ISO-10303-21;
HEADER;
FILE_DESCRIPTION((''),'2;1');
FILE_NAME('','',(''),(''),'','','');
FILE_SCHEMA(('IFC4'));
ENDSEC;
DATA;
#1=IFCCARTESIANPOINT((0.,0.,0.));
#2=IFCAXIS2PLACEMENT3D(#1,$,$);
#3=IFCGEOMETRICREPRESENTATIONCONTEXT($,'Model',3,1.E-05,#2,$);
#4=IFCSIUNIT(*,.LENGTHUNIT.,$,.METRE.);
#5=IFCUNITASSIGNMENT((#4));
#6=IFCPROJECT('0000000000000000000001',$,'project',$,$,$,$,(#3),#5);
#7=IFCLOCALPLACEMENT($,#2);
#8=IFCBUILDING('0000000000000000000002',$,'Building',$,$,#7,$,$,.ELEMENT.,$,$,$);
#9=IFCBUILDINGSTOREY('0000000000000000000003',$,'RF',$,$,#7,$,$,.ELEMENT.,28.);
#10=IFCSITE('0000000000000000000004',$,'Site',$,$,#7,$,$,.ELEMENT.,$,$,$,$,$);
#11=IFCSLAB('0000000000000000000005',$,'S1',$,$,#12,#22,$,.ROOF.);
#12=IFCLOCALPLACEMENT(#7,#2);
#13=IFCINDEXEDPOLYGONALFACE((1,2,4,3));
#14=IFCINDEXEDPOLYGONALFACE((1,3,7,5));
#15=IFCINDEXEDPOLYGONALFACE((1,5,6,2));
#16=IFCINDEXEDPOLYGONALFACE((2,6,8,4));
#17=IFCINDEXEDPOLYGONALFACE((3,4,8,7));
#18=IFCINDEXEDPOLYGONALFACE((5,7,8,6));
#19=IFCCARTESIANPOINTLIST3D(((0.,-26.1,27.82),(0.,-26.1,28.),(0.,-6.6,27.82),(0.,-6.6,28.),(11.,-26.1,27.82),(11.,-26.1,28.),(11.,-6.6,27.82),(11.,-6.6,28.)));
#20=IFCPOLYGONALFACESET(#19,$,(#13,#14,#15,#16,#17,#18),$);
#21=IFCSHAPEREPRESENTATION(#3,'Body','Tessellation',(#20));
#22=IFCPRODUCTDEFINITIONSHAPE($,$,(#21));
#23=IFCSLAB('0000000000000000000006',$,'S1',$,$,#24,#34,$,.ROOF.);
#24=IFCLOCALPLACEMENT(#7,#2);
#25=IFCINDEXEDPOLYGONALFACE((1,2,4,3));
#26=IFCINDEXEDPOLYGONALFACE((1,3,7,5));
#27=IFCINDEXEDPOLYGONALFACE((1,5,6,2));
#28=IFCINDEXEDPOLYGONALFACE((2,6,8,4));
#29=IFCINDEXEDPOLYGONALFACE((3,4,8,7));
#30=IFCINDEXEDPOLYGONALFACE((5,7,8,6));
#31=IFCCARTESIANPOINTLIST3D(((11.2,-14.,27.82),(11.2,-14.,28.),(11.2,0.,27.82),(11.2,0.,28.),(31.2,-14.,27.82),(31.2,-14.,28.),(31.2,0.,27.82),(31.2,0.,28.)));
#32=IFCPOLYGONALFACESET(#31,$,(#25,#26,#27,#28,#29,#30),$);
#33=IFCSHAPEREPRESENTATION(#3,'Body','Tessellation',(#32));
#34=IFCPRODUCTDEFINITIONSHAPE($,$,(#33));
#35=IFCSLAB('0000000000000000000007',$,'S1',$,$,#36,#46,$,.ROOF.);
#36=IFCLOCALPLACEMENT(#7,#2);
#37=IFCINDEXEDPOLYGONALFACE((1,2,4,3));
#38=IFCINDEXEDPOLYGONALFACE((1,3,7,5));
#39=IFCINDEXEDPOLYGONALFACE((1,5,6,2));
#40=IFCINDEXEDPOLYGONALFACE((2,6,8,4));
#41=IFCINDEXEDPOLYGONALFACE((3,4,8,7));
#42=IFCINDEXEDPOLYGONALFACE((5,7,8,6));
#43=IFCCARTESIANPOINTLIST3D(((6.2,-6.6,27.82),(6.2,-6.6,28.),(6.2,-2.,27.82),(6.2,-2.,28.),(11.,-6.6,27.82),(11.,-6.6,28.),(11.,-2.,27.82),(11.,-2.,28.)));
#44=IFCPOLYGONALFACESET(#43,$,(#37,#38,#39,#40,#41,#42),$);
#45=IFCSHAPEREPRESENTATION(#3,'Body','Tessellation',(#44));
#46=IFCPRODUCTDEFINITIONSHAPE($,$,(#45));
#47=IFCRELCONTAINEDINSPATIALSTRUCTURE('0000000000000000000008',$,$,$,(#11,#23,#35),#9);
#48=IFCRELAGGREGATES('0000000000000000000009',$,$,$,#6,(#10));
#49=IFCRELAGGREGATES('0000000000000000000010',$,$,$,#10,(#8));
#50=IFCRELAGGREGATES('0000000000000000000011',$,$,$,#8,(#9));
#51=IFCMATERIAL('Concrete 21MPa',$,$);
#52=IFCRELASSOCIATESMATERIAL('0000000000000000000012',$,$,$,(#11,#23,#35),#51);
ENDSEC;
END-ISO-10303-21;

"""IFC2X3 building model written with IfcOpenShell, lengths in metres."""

from ifc_helpers import new_model, si_unit, frame, origin, origin_2d, place, context, project, spatial, rectangle, extrude, material, element, save


model = new_model("IFC2X3")

# Units and contexts
model_context = context("Model", 3, precision=1e-05, world=origin())
ifc_project = project(units=[si_unit("LENGTHUNIT", "METRE")], contexts=[model_context])

# Site, building, storey
placement = place(None, origin())
site = spatial("IfcSite", under=ifc_project, at=placement, Name="Site", CompositionType="ELEMENT")
building = spatial("IfcBuilding", under=site, at=placement, Name="Building", CompositionType="ELEMENT")
storey = spatial("IfcBuildingStorey", under=building, at=placement, Name="RF", CompositionType="ELEMENT", Elevation=28.0)

# Slabs
ifc_material = material(Name="Concrete 21MPa")
slab_1_placement = place(None, frame((5.5, -16.35, 27.82)))
element("IfcSlab", 1, at=slab_1_placement, inside=storey, material=ifc_material, Name="S1", PredefinedType="ROOF", context=model_context, shape_type="SweptSolid", body=[
    extrude(rectangle(XDim=11.0, YDim=19.5, at=origin_2d()), origin(), (0.0, 0.0, 1.0), 0.18),
])
slab_2_placement = place(None, frame((21.2, -7.0, 27.82)))
element("IfcSlab", 2, at=slab_2_placement, inside=storey, material=ifc_material, Name="S1", PredefinedType="ROOF", context=model_context, shape_type="SweptSolid", body=[
    extrude(rectangle(XDim=20.0, YDim=14.0, at=origin_2d()), origin(), (0.0, 0.0, 1.0), 0.18),
])
slab_3_placement = place(None, frame((8.6, -4.3, 27.82)))
element("IfcSlab", 3, at=slab_3_placement, inside=storey, material=ifc_material, Name="S1", PredefinedType="ROOF", context=model_context, shape_type="SweptSolid", body=[
    extrude(rectangle(XDim=4.8, YDim=4.6, at=origin_2d()), origin(), (0.0, 0.0, 1.0), 0.18),
])

save(model, "model.ifc")
